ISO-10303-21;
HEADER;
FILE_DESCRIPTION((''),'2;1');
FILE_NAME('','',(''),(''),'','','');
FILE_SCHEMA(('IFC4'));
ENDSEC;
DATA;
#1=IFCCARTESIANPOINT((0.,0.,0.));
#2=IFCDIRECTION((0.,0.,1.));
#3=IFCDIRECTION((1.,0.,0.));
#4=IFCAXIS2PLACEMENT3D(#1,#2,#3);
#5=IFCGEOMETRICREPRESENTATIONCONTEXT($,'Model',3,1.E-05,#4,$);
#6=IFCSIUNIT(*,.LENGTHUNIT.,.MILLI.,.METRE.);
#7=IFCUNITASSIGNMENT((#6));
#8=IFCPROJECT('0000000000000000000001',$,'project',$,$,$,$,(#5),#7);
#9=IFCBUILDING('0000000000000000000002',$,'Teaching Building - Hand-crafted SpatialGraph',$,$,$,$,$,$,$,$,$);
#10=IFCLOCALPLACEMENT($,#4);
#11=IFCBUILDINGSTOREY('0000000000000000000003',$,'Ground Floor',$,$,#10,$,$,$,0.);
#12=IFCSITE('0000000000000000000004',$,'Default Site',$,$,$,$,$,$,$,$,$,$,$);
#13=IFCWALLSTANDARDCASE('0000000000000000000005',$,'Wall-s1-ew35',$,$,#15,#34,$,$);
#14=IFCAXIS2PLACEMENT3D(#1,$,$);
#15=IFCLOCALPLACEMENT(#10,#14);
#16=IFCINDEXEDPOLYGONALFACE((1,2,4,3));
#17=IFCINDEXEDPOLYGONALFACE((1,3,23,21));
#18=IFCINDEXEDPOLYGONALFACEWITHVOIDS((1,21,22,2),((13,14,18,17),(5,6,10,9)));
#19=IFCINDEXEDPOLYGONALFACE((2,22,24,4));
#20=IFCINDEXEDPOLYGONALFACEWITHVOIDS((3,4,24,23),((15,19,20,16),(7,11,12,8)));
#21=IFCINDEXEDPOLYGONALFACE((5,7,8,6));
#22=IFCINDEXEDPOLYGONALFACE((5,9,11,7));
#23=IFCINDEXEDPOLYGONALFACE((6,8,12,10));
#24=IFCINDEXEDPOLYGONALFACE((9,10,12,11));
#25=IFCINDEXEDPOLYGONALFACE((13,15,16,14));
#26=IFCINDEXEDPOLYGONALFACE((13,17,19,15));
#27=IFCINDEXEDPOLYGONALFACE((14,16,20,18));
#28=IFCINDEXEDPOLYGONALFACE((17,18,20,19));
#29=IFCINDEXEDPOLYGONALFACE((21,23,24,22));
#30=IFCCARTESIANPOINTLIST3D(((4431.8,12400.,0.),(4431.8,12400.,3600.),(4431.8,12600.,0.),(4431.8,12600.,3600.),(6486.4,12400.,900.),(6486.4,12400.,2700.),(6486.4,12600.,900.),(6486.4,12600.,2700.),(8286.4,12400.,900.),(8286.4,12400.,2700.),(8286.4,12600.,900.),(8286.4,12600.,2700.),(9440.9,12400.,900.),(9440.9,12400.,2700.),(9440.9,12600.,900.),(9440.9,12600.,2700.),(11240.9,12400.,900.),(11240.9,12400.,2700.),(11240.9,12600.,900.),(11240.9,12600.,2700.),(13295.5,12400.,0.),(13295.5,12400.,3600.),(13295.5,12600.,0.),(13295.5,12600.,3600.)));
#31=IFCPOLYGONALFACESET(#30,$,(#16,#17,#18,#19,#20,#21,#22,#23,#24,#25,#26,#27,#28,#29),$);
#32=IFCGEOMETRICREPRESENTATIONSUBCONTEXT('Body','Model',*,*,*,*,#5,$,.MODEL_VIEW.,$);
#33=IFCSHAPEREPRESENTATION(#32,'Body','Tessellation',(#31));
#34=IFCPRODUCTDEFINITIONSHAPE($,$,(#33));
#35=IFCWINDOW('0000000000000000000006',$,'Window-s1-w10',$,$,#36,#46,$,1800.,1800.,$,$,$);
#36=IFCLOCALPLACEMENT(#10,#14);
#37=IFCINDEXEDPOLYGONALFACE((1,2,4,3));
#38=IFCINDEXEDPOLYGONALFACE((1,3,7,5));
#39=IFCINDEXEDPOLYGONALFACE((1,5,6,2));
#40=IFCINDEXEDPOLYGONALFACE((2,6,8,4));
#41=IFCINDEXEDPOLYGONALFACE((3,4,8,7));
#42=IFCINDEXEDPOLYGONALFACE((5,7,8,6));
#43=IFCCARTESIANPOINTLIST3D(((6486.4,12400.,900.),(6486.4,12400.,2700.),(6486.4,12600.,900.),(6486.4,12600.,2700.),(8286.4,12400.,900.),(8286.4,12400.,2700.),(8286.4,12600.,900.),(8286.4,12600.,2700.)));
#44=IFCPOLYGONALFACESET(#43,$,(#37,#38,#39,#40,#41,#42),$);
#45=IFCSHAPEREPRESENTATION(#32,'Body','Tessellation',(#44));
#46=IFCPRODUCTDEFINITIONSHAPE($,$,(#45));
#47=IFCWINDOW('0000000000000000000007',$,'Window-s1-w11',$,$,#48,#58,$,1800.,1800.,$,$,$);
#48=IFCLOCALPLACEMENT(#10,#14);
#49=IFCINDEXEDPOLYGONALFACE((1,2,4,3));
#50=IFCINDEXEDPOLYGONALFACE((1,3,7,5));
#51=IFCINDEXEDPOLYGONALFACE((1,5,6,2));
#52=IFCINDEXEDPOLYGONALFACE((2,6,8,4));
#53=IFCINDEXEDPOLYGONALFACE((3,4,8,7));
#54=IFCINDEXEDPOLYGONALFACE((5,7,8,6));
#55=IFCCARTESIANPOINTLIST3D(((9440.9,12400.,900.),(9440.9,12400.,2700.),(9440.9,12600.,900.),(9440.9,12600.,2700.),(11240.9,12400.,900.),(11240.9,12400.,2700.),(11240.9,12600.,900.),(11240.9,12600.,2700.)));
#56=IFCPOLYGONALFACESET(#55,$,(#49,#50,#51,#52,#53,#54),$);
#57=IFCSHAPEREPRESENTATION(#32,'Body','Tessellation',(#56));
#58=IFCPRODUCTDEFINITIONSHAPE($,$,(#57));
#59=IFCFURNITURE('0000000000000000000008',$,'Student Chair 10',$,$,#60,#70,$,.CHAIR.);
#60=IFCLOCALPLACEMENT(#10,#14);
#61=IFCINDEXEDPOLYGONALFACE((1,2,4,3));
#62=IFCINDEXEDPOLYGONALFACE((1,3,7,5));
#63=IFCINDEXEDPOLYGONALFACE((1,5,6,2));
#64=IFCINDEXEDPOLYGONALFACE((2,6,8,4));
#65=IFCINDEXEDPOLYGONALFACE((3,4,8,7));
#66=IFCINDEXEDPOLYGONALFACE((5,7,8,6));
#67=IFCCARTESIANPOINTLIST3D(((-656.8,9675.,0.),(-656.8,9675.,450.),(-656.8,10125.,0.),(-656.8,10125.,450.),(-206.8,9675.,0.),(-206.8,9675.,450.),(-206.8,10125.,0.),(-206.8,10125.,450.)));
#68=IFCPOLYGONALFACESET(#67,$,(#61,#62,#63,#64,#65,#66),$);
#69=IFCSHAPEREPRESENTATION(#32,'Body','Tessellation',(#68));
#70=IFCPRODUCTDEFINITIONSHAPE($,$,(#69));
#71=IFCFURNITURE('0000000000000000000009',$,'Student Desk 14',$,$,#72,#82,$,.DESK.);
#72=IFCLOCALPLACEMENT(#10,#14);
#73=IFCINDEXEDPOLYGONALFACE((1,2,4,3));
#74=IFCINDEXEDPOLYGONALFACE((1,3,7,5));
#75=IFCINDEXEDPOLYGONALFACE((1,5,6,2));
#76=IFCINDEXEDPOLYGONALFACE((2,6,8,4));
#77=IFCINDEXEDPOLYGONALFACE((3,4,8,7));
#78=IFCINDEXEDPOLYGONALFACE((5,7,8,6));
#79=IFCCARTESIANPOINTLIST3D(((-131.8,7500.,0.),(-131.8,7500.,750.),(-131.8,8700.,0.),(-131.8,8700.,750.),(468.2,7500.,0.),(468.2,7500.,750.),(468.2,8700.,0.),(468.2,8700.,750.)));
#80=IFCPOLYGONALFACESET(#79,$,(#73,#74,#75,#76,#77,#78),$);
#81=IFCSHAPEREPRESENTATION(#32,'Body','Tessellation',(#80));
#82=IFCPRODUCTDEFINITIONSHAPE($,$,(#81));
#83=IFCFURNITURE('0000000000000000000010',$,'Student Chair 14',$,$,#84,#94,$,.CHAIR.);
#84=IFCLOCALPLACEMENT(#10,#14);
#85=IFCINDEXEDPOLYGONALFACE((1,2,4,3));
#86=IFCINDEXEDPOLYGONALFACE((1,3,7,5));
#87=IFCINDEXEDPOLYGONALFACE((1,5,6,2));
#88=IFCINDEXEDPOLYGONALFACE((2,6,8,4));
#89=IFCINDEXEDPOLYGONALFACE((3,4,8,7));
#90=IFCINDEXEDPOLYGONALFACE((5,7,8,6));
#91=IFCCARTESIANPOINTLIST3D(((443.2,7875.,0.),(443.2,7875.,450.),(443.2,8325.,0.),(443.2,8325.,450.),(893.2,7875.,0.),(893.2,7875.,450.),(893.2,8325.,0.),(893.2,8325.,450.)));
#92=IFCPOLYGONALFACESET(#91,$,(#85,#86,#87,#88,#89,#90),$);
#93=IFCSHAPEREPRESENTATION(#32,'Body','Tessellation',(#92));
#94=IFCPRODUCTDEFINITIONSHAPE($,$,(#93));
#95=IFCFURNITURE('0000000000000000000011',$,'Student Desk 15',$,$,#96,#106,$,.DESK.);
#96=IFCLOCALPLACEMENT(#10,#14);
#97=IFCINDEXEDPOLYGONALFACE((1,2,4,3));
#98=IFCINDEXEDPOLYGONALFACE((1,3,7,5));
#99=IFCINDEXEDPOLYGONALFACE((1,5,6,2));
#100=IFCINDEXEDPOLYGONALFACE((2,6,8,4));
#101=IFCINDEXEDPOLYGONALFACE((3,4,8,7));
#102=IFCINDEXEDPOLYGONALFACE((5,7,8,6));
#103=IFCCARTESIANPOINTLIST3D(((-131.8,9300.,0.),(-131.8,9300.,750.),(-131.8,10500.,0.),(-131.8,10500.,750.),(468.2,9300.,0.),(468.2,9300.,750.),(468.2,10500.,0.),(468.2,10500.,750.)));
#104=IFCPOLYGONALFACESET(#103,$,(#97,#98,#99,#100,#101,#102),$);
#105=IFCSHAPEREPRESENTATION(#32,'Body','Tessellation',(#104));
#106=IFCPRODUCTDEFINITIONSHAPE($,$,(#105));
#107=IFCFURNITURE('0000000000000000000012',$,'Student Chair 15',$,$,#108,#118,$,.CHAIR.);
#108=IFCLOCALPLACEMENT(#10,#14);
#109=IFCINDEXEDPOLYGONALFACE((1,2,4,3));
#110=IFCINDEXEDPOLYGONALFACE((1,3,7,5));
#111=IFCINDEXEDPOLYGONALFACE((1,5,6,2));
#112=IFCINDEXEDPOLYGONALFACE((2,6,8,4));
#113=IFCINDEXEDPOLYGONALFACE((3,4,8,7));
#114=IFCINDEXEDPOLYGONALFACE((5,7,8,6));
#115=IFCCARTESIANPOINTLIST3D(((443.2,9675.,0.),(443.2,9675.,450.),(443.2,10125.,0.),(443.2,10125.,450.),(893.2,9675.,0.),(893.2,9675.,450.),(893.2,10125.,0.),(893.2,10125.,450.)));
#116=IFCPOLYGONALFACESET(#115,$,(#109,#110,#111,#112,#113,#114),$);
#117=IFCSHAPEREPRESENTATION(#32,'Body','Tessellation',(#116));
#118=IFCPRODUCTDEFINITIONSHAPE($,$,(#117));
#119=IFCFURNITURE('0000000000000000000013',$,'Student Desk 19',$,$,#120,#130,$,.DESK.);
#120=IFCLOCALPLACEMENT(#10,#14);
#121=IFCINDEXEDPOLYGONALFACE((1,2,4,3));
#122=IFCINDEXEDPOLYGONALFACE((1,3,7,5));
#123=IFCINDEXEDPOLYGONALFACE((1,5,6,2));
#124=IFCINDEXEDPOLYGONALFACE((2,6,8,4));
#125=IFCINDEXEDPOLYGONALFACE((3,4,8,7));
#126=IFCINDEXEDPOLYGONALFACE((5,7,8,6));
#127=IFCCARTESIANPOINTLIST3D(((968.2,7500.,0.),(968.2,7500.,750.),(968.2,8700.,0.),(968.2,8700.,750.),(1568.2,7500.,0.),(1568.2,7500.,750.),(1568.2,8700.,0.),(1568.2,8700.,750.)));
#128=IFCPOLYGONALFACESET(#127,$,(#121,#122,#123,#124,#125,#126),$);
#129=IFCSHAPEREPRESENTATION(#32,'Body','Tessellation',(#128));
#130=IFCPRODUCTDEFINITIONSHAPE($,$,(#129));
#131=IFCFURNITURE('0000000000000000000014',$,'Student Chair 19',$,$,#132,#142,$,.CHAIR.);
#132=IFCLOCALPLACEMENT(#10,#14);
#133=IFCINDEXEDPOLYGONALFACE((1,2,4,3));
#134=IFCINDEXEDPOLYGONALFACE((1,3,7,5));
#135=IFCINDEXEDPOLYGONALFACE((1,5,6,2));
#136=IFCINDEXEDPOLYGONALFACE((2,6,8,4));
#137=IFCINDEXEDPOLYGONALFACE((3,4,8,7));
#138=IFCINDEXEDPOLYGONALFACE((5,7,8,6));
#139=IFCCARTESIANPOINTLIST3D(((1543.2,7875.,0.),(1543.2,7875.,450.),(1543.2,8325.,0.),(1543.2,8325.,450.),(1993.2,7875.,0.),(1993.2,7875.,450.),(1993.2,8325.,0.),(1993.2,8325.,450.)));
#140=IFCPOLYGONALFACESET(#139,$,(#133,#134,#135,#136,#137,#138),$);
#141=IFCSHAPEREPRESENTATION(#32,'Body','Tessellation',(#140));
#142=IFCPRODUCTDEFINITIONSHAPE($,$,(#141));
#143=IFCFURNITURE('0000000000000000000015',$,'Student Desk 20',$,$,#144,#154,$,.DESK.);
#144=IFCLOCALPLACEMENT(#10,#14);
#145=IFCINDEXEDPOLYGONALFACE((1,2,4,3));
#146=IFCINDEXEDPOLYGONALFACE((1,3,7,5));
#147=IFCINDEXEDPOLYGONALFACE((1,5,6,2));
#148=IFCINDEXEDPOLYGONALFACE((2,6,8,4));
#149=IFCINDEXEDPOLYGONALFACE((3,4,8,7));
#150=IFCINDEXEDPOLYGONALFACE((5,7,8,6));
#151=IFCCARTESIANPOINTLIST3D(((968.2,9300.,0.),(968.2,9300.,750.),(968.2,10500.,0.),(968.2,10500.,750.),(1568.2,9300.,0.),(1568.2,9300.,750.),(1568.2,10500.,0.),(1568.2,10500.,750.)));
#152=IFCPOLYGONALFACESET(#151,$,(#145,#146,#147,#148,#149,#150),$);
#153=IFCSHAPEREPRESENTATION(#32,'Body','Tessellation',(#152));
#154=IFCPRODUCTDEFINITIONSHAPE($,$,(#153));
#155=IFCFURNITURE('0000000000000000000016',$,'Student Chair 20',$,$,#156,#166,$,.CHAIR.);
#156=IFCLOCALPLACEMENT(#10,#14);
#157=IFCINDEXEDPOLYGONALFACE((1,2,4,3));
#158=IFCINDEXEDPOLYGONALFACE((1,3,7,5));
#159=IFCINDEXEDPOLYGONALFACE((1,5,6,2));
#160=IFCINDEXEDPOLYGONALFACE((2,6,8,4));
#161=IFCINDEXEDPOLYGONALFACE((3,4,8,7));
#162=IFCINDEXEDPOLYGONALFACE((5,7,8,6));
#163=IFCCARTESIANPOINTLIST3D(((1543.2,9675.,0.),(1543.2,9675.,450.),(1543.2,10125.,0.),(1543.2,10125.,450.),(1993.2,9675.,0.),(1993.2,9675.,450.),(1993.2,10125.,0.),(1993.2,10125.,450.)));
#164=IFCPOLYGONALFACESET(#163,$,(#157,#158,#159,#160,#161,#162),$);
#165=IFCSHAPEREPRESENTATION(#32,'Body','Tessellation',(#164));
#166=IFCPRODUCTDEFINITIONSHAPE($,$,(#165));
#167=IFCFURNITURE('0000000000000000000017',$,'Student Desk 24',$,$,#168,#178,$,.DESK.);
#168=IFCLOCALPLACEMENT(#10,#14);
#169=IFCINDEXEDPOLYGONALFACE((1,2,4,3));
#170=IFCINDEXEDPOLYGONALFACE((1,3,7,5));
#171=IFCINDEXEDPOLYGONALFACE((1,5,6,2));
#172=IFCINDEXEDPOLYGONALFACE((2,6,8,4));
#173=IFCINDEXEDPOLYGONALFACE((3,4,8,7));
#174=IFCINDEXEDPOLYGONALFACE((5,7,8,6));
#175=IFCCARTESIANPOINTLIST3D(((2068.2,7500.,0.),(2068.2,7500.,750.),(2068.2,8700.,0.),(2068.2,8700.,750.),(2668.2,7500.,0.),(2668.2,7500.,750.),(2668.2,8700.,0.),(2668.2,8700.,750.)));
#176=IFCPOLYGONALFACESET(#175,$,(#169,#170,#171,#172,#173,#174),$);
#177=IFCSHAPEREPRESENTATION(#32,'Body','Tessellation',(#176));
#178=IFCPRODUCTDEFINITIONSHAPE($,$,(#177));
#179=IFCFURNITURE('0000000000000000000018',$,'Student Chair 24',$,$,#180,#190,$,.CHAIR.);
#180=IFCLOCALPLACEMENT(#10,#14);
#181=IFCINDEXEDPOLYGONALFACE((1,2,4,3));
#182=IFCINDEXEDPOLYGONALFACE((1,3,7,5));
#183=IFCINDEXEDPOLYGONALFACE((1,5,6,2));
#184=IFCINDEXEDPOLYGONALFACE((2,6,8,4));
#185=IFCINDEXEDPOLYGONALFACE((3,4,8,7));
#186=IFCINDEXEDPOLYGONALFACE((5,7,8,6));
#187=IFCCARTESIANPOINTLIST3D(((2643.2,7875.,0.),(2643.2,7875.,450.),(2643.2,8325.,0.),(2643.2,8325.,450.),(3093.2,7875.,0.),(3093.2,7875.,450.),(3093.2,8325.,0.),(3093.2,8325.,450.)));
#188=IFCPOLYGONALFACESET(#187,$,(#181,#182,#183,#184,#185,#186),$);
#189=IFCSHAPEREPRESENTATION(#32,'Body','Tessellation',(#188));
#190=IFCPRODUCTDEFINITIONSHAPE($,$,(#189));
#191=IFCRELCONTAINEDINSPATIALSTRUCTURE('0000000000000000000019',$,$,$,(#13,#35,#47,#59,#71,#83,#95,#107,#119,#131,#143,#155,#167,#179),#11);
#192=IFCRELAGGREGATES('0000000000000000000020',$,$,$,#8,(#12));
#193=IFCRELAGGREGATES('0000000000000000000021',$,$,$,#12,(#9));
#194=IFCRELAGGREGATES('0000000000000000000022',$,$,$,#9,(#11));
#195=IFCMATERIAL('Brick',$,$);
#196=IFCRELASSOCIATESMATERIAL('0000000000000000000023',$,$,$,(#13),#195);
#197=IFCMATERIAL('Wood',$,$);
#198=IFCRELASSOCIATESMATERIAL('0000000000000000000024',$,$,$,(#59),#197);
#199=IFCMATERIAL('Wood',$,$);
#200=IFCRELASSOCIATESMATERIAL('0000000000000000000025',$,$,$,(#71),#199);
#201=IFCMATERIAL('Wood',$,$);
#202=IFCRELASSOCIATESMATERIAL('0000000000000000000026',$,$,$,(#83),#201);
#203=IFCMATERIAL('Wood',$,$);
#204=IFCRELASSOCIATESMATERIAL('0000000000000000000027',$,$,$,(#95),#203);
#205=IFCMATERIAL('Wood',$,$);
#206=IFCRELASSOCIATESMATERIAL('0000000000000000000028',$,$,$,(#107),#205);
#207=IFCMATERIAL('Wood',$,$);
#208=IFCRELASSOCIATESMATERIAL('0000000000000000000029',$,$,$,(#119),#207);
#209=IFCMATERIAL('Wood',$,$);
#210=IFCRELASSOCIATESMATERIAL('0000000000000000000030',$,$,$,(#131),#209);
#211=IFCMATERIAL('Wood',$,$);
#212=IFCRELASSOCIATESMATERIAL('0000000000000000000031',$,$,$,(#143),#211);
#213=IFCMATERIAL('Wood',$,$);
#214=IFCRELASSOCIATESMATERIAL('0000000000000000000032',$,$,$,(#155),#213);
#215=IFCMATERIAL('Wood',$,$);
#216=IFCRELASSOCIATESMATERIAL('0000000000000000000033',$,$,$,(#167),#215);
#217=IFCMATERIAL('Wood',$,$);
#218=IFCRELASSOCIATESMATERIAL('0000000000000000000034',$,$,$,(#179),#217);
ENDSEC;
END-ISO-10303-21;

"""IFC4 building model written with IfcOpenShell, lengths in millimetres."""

from ifc_helpers import new_model, si_unit, frame, frame_2d, origin_with_axes, origin_2d, place, context, subcontext, project, spatial, rectangle, extrude, material, element, fill, save


model = new_model("IFC4")

# Units and contexts
model_context = context("Model", 3, precision=1e-05, world=origin_with_axes())
body_context = subcontext(model_context, "Body", "Model", "MODEL_VIEW")
ifc_project = project(units=[si_unit("LENGTHUNIT", "METRE", prefix="MILLI")], contexts=[model_context])

# Site, building, storey
site = spatial("IfcSite", under=ifc_project, Name="Default Site")
building = spatial("IfcBuilding", under=site, Name="Teaching Building - Hand-crafted SpatialGraph")
storey_placement = place(None, origin_with_axes())
storey = spatial("IfcBuildingStorey", under=building, at=storey_placement, Name="Ground Floor", Elevation=0.0)

# Wall, openings, windows
ifc_material_1 = material(Name="Brick")
wall_placement = place(storey_placement, frame((4431.8, 12500.0, 0.0), z_axis=(0.0, 0.0, 1.0), x_axis=(1.0, 0.0, 0.0)))
wall = element("IfcWallStandardCase", 1, at=wall_placement, inside=storey, material=ifc_material_1, Name="Wall-s1-ew35", context=body_context, shape_type="SweptSolid", body=[
    extrude(rectangle(XDim=8863.6, YDim=200.0, at=frame_2d((4431.8, 0.0))), origin_with_axes(), (0.0, 0.0, 1.0), 3600.0),
])
opening_1_placement = place(wall_placement, frame((2054.5, 0.0, 900.0), z_axis=(0.0, 0.0, 1.0), x_axis=(1.0, 0.0, 0.0)))
opening_1 = element("IfcOpeningElement", 2, at=opening_1_placement, cuts=wall, context=body_context, shape_type="SweptSolid", body=[
    extrude(rectangle(XDim=1800.0, YDim=400.0, at=frame_2d((900.0, 0.0))), origin_with_axes(), (0.0, 0.0, 1.0), 1800.0),
])
opening_2_placement = place(wall_placement, frame((5009.1, 0.0, 900.0), z_axis=(0.0, 0.0, 1.0), x_axis=(1.0, 0.0, 0.0)))
opening_2 = element("IfcOpeningElement", 3, at=opening_2_placement, cuts=wall, context=body_context, shape_type="SweptSolid", body=[
    extrude(rectangle(XDim=1800.0, YDim=400.0, at=frame_2d((900.0, 0.0))), origin_with_axes(), (0.0, 0.0, 1.0), 1800.0),
])
window_1_placement = place(storey_placement, frame((6486.4, 12500.0, 900.0), z_axis=(0.0, 0.0, 1.0), x_axis=(1.0, 0.0, 0.0)))
window_1 = element("IfcWindow", 4, at=window_1_placement, inside=storey, Name="Window-s1-w10", OverallHeight=1800.0, OverallWidth=1800.0, context=body_context, shape_type="SweptSolid", body=[
    extrude(rectangle(XDim=1800.0, YDim=200.0, at=frame_2d((900.0, 0.0))), origin_with_axes(), (0.0, 0.0, 1.0), 1800.0),
])
fill(opening_1, window_1)
window_2_placement = place(storey_placement, frame((9440.9, 12500.0, 900.0), z_axis=(0.0, 0.0, 1.0), x_axis=(1.0, 0.0, 0.0)))
window_2 = element("IfcWindow", 5, at=window_2_placement, inside=storey, Name="Window-s1-w11", OverallHeight=1800.0, OverallWidth=1800.0, context=body_context, shape_type="SweptSolid", body=[
    extrude(rectangle(XDim=1800.0, YDim=200.0, at=frame_2d((900.0, 0.0))), origin_with_axes(), (0.0, 0.0, 1.0), 1800.0),
])
fill(opening_2, window_2)

# Furniture
ifc_material_2 = material(Name="Wood")
furniture_1_placement = place(storey_placement, frame((-431.8, 9900.0, 0.0), z_axis=(0.0, 0.0, 1.0), x_axis=(1.0, 0.0, 0.0)))
element("IfcFurniture", 6, at=furniture_1_placement, inside=storey, material=ifc_material_2, Name="Student Chair 10", PredefinedType="CHAIR", context=body_context, shape_type="SweptSolid", body=[
    extrude(rectangle(XDim=450.0, YDim=450.0, at=origin_2d()), origin_with_axes(), (0.0, 0.0, 1.0), 450.0),
])
ifc_material_3 = material(Name="Wood")
furniture_2_placement = place(storey_placement, frame((168.2, 8100.0, 0.0), z_axis=(0.0, 0.0, 1.0), x_axis=(0.0, 1.0, 0.0)))
element("IfcFurniture", 7, at=furniture_2_placement, inside=storey, material=ifc_material_3, Name="Student Desk 14", PredefinedType="DESK", context=body_context, shape_type="SweptSolid", body=[
    extrude(rectangle(XDim=1200.0, YDim=600.0, at=origin_2d()), origin_with_axes(), (0.0, 0.0, 1.0), 750.0),
])
ifc_material_4 = material(Name="Wood")
furniture_3_placement = place(storey_placement, frame((668.2, 8100.0, 0.0), z_axis=(0.0, 0.0, 1.0), x_axis=(1.0, 0.0, 0.0)))
element("IfcFurniture", 8, at=furniture_3_placement, inside=storey, material=ifc_material_4, Name="Student Chair 14", PredefinedType="CHAIR", context=body_context, shape_type="SweptSolid", body=[
    extrude(rectangle(XDim=450.0, YDim=450.0, at=origin_2d()), origin_with_axes(), (0.0, 0.0, 1.0), 450.0),
])
ifc_material_5 = material(Name="Wood")
furniture_4_placement = place(storey_placement, frame((168.2, 9900.0, 0.0), z_axis=(0.0, 0.0, 1.0), x_axis=(0.0, 1.0, 0.0)))
element("IfcFurniture", 9, at=furniture_4_placement, inside=storey, material=ifc_material_5, Name="Student Desk 15", PredefinedType="DESK", context=body_context, shape_type="SweptSolid", body=[
    extrude(rectangle(XDim=1200.0, YDim=600.0, at=origin_2d()), origin_with_axes(), (0.0, 0.0, 1.0), 750.0),
])
ifc_material_6 = material(Name="Wood")
furniture_5_placement = place(storey_placement, frame((668.2, 9900.0, 0.0), z_axis=(0.0, 0.0, 1.0), x_axis=(1.0, 0.0, 0.0)))
element("IfcFurniture", 10, at=furniture_5_placement, inside=storey, material=ifc_material_6, Name="Student Chair 15", PredefinedType="CHAIR", context=body_context, shape_type="SweptSolid", body=[
    extrude(rectangle(XDim=450.0, YDim=450.0, at=origin_2d()), origin_with_axes(), (0.0, 0.0, 1.0), 450.0),
])
ifc_material_7 = material(Name="Wood")
furniture_6_placement = place(storey_placement, frame((1268.2, 8100.0, 0.0), z_axis=(0.0, 0.0, 1.0), x_axis=(0.0, 1.0, 0.0)))
element("IfcFurniture", 11, at=furniture_6_placement, inside=storey, material=ifc_material_7, Name="Student Desk 19", PredefinedType="DESK", context=body_context, shape_type="SweptSolid", body=[
    extrude(rectangle(XDim=1200.0, YDim=600.0, at=origin_2d()), origin_with_axes(), (0.0, 0.0, 1.0), 750.0),
])
ifc_material_8 = material(Name="Wood")
furniture_7_placement = place(storey_placement, frame((1768.2, 8100.0, 0.0), z_axis=(0.0, 0.0, 1.0), x_axis=(1.0, 0.0, 0.0)))
element("IfcFurniture", 12, at=furniture_7_placement, inside=storey, material=ifc_material_8, Name="Student Chair 19", PredefinedType="CHAIR", context=body_context, shape_type="SweptSolid", body=[
    extrude(rectangle(XDim=450.0, YDim=450.0, at=origin_2d()), origin_with_axes(), (0.0, 0.0, 1.0), 450.0),
])
ifc_material_9 = material(Name="Wood")
furniture_8_placement = place(storey_placement, frame((1268.2, 9900.0, 0.0), z_axis=(0.0, 0.0, 1.0), x_axis=(0.0, 1.0, 0.0)))
element("IfcFurniture", 13, at=furniture_8_placement, inside=storey, material=ifc_material_9, Name="Student Desk 20", PredefinedType="DESK", context=body_context, shape_type="SweptSolid", body=[
    extrude(rectangle(XDim=1200.0, YDim=600.0, at=origin_2d()), origin_with_axes(), (0.0, 0.0, 1.0), 750.0),
])
ifc_material_10 = material(Name="Wood")
furniture_9_placement = place(storey_placement, frame((1768.2, 9900.0, 0.0), z_axis=(0.0, 0.0, 1.0), x_axis=(1.0, 0.0, 0.0)))
element("IfcFurniture", 14, at=furniture_9_placement, inside=storey, material=ifc_material_10, Name="Student Chair 20", PredefinedType="CHAIR", context=body_context, shape_type="SweptSolid", body=[
    extrude(rectangle(XDim=450.0, YDim=450.0, at=origin_2d()), origin_with_axes(), (0.0, 0.0, 1.0), 450.0),
])
ifc_material_11 = material(Name="Wood")
furniture_10_placement = place(storey_placement, frame((2368.2, 8100.0, 0.0), z_axis=(0.0, 0.0, 1.0), x_axis=(0.0, 1.0, 0.0)))
element("IfcFurniture", 15, at=furniture_10_placement, inside=storey, material=ifc_material_11, Name="Student Desk 24", PredefinedType="DESK", context=body_context, shape_type="SweptSolid", body=[
    extrude(rectangle(XDim=1200.0, YDim=600.0, at=origin_2d()), origin_with_axes(), (0.0, 0.0, 1.0), 750.0),
])
ifc_material_12 = material(Name="Wood")
furniture_11_placement = place(storey_placement, frame((2868.2, 8100.0, 0.0), z_axis=(0.0, 0.0, 1.0), x_axis=(1.0, 0.0, 0.0)))
element("IfcFurniture", 16, at=furniture_11_placement, inside=storey, material=ifc_material_12, Name="Student Chair 24", PredefinedType="CHAIR", context=body_context, shape_type="SweptSolid", body=[
    extrude(rectangle(XDim=450.0, YDim=450.0, at=origin_2d()), origin_with_axes(), (0.0, 0.0, 1.0), 450.0),
])

save(model, "model.ifc")
